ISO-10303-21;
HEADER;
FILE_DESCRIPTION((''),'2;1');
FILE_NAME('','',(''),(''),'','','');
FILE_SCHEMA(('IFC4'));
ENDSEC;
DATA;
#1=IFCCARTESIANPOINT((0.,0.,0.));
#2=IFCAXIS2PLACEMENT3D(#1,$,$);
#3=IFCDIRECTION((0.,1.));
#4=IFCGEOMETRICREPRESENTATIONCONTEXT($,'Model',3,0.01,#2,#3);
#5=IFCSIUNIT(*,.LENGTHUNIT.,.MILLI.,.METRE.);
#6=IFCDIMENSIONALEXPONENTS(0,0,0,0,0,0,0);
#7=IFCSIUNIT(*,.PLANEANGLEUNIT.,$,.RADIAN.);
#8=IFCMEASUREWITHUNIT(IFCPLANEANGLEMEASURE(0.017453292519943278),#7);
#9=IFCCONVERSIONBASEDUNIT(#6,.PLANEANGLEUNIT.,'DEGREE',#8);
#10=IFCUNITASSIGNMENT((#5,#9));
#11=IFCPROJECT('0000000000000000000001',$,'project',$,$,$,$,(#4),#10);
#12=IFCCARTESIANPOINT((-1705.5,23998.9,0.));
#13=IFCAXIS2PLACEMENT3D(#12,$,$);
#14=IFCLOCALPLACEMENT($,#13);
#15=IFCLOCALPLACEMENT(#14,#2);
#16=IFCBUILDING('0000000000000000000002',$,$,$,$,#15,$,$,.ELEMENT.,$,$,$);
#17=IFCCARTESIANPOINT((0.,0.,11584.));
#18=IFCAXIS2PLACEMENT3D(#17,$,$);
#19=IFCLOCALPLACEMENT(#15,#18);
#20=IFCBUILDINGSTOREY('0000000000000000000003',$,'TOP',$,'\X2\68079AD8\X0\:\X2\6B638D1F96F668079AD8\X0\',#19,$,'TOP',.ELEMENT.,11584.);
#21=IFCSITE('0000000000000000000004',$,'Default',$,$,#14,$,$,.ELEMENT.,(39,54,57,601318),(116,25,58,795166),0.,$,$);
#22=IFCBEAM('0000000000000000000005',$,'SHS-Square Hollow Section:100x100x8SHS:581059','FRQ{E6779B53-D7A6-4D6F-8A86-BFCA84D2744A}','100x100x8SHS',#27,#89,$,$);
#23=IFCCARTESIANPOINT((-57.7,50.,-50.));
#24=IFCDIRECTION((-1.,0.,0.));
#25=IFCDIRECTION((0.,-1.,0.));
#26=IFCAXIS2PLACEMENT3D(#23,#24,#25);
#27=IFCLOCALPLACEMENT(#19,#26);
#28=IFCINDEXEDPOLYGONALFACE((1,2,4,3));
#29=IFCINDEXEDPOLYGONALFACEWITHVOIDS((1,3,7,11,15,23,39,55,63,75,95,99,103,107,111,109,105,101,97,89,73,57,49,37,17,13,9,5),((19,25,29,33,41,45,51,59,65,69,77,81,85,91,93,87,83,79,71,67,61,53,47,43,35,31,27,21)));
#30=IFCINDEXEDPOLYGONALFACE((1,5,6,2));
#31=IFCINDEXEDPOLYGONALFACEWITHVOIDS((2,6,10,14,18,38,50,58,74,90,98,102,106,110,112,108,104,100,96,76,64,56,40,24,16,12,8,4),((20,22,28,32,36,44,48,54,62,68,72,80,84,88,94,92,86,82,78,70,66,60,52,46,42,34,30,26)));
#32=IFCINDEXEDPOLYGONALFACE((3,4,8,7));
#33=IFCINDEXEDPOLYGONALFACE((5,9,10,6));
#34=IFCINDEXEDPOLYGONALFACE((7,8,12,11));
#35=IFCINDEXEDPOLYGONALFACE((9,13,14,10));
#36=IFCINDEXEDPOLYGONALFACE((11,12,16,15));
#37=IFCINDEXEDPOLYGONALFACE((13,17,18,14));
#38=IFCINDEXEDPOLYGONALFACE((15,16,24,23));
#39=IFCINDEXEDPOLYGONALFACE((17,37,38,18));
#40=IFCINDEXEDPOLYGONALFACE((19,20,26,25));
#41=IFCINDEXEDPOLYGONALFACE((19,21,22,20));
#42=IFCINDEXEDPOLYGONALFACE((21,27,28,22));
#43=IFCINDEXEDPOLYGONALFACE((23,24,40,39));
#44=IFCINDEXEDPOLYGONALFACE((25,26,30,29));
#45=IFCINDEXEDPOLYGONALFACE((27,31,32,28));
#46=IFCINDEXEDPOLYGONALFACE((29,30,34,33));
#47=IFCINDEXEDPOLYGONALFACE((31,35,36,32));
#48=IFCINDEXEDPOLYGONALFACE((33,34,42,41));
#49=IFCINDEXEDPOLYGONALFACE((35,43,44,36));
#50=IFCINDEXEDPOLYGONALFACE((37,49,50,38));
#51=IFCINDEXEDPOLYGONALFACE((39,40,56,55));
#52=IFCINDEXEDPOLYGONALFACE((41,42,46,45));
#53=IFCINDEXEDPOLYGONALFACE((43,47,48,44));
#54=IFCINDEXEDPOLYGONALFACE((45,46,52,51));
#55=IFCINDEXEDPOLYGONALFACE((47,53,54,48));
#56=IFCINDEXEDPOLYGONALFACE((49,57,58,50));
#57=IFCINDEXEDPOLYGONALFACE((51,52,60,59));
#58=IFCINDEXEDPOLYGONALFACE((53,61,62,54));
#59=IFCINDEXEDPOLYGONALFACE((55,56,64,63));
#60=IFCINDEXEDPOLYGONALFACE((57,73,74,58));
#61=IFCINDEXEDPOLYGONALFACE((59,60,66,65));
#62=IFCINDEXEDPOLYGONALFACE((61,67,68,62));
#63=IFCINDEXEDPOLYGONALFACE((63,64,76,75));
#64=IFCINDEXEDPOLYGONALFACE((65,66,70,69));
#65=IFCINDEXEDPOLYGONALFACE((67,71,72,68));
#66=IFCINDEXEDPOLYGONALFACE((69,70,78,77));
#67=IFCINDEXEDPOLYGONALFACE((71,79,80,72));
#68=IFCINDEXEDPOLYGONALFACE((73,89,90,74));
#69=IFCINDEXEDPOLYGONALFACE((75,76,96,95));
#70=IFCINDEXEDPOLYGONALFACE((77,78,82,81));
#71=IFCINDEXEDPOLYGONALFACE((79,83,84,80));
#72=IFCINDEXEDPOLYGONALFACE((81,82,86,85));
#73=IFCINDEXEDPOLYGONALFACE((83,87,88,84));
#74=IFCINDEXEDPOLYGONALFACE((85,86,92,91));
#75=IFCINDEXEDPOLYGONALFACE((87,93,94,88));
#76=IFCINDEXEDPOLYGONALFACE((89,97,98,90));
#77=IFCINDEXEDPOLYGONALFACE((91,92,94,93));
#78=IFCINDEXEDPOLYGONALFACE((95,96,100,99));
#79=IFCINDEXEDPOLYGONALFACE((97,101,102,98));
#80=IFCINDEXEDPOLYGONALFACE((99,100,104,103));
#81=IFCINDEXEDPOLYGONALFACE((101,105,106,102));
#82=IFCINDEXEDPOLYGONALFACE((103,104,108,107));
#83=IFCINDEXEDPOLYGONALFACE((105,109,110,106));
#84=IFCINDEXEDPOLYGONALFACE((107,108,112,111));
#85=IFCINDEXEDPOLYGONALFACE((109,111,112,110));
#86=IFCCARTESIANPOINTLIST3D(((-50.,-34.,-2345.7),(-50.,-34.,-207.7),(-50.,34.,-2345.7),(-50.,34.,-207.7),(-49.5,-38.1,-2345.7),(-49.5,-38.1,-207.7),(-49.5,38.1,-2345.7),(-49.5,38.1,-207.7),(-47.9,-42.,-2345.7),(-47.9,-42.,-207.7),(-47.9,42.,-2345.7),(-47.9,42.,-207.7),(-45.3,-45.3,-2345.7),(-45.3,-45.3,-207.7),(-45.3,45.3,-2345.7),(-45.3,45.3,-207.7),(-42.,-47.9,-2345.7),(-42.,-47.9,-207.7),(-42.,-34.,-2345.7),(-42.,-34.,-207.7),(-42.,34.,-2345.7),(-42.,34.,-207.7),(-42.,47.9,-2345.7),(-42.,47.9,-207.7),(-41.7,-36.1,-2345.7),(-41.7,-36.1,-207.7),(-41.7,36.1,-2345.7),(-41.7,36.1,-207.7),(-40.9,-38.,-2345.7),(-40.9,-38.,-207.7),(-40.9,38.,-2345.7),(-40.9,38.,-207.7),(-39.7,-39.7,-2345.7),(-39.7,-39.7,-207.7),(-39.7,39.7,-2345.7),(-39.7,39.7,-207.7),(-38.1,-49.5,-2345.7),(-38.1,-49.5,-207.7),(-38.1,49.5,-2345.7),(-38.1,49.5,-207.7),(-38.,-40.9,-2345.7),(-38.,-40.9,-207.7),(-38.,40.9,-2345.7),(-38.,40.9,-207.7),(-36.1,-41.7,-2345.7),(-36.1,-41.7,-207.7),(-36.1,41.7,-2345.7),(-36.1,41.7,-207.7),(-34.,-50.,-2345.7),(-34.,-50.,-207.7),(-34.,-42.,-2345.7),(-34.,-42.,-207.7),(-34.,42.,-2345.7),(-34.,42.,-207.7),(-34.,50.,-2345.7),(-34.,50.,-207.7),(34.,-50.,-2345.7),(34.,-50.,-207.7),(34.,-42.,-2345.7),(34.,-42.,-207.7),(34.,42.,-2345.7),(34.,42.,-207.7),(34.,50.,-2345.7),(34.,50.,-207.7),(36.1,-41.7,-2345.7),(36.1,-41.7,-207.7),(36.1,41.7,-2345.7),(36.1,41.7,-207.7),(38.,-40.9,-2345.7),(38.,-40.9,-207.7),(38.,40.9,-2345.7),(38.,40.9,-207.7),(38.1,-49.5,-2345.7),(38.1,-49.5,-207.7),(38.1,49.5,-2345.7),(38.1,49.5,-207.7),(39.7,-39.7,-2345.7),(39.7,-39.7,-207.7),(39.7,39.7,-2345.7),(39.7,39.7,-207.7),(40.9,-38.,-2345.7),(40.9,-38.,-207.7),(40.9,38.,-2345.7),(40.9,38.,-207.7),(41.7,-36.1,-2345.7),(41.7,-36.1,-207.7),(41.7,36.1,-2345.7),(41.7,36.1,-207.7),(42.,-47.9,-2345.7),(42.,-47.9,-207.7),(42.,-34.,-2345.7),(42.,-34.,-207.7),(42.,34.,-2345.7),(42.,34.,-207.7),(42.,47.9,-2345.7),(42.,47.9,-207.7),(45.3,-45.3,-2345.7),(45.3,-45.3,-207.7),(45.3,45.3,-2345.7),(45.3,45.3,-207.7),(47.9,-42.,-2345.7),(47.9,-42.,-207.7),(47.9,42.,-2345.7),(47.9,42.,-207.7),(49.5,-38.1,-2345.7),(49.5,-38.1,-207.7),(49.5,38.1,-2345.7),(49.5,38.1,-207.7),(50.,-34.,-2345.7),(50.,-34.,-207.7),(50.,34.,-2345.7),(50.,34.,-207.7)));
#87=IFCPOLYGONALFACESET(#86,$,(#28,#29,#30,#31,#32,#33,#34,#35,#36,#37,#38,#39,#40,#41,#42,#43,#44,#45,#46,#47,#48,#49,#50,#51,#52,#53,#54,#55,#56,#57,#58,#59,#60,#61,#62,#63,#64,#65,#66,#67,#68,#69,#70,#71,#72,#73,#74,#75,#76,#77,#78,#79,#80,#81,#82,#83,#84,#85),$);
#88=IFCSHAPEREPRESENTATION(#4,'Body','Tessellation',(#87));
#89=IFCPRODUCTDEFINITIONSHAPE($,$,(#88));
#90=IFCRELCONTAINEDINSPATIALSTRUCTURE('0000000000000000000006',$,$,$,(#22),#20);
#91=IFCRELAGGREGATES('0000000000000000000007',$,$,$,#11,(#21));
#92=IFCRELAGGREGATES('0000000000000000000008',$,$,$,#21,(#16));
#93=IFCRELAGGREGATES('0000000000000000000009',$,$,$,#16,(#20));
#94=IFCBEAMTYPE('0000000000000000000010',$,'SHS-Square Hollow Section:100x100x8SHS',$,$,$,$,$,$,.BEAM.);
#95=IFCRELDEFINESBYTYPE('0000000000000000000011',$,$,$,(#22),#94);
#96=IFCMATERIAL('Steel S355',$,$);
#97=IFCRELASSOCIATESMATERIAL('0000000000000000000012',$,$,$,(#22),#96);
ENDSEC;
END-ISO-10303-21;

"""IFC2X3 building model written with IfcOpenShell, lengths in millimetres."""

from ifc_helpers import new_model, entity, si_unit, converted_unit, direction, frame, origin, origin_2d, place, context, project, spatial, hollow_rectangle, extrude, clip, halfspace, material, type_object, element, save


model = new_model("IFC2X3")

# Units and contexts
model_context = context("Model", 3, precision=0.01, world=origin(), true_north=direction((0.0, 1.0)))
ifc_project = project(units=[si_unit("LENGTHUNIT", "METRE", prefix="MILLI"), converted_unit("PLANEANGLEUNIT", "DEGREE", entity("IfcPlaneAngleMeasure", 0.017453292519943278), si_unit("PLANEANGLEUNIT", "RADIAN"), dimensions=[0, 0, 0, 0, 0, 0, 0])], contexts=[model_context])

# Site, building, storey
site_placement = place(None, frame((-1705.5, 23998.9, 0.0)))
site = spatial("IfcSite", under=ifc_project, at=site_placement, Name="Default", CompositionType="ELEMENT", RefLatitude=(39, 54, 57, 601318), RefLongitude=(116, 25, 58, 795166), RefElevation=0.0)
building_placement = place(site_placement, origin())
building = spatial("IfcBuilding", under=site, at=building_placement, CompositionType="ELEMENT")
storey_placement = place(building_placement, frame((0.0, 0.0, 11584.0)))
storey = spatial("IfcBuildingStorey", under=building, at=storey_placement, Name="TOP", ObjectType="标高:正负零标高", LongName="TOP", CompositionType="ELEMENT", Elevation=11584.0)

# Shared definitions
ifc_material_1 = material(Name="Steel S355")

# Beam
beam_type_1 = type_object("IfcBeamType", Name="SHS-Square Hollow Section:100x100x8SHS", PredefinedType="BEAM")
beam_1_placement = place(storey_placement, frame((-57.7, 50.0, -50.0), z_axis=(-1.0, 0.0, 0.0), x_axis=(0.0, -1.0, 0.0)))
element("IfcBeam", 1, at=beam_1_placement, inside=storey, type_object=beam_type_1, material=ifc_material_1, Name="SHS-Square Hollow Section:100x100x8SHS:581059", Description="FRQ{E6779B53-D7A6-4D6F-8A86-BFCA84D2744A}", ObjectType="100x100x8SHS", context=model_context, shape_type="Clipping", body=[
    clip(clip(extrude(hollow_rectangle(XDim=100.0, YDim=100.0, WallThickness=8.0, InnerFilletRadius=8.0, OuterFilletRadius=16.0, at=origin_2d()), origin(), (0.0, 0.0, -1.0), 2551.4), halfspace(frame((50.0, -11534.0, -2345.7), z_axis=(0.0, 0.0, 1.0), x_axis=(1.0, 0.0, 0.0)), True)), halfspace(frame((50.0, -11534.0, -207.7), z_axis=(0.0, 0.0, -1.0), x_axis=(-1.0, 0.0, 0.0)), True)),
])

save(model, "model.ifc")
